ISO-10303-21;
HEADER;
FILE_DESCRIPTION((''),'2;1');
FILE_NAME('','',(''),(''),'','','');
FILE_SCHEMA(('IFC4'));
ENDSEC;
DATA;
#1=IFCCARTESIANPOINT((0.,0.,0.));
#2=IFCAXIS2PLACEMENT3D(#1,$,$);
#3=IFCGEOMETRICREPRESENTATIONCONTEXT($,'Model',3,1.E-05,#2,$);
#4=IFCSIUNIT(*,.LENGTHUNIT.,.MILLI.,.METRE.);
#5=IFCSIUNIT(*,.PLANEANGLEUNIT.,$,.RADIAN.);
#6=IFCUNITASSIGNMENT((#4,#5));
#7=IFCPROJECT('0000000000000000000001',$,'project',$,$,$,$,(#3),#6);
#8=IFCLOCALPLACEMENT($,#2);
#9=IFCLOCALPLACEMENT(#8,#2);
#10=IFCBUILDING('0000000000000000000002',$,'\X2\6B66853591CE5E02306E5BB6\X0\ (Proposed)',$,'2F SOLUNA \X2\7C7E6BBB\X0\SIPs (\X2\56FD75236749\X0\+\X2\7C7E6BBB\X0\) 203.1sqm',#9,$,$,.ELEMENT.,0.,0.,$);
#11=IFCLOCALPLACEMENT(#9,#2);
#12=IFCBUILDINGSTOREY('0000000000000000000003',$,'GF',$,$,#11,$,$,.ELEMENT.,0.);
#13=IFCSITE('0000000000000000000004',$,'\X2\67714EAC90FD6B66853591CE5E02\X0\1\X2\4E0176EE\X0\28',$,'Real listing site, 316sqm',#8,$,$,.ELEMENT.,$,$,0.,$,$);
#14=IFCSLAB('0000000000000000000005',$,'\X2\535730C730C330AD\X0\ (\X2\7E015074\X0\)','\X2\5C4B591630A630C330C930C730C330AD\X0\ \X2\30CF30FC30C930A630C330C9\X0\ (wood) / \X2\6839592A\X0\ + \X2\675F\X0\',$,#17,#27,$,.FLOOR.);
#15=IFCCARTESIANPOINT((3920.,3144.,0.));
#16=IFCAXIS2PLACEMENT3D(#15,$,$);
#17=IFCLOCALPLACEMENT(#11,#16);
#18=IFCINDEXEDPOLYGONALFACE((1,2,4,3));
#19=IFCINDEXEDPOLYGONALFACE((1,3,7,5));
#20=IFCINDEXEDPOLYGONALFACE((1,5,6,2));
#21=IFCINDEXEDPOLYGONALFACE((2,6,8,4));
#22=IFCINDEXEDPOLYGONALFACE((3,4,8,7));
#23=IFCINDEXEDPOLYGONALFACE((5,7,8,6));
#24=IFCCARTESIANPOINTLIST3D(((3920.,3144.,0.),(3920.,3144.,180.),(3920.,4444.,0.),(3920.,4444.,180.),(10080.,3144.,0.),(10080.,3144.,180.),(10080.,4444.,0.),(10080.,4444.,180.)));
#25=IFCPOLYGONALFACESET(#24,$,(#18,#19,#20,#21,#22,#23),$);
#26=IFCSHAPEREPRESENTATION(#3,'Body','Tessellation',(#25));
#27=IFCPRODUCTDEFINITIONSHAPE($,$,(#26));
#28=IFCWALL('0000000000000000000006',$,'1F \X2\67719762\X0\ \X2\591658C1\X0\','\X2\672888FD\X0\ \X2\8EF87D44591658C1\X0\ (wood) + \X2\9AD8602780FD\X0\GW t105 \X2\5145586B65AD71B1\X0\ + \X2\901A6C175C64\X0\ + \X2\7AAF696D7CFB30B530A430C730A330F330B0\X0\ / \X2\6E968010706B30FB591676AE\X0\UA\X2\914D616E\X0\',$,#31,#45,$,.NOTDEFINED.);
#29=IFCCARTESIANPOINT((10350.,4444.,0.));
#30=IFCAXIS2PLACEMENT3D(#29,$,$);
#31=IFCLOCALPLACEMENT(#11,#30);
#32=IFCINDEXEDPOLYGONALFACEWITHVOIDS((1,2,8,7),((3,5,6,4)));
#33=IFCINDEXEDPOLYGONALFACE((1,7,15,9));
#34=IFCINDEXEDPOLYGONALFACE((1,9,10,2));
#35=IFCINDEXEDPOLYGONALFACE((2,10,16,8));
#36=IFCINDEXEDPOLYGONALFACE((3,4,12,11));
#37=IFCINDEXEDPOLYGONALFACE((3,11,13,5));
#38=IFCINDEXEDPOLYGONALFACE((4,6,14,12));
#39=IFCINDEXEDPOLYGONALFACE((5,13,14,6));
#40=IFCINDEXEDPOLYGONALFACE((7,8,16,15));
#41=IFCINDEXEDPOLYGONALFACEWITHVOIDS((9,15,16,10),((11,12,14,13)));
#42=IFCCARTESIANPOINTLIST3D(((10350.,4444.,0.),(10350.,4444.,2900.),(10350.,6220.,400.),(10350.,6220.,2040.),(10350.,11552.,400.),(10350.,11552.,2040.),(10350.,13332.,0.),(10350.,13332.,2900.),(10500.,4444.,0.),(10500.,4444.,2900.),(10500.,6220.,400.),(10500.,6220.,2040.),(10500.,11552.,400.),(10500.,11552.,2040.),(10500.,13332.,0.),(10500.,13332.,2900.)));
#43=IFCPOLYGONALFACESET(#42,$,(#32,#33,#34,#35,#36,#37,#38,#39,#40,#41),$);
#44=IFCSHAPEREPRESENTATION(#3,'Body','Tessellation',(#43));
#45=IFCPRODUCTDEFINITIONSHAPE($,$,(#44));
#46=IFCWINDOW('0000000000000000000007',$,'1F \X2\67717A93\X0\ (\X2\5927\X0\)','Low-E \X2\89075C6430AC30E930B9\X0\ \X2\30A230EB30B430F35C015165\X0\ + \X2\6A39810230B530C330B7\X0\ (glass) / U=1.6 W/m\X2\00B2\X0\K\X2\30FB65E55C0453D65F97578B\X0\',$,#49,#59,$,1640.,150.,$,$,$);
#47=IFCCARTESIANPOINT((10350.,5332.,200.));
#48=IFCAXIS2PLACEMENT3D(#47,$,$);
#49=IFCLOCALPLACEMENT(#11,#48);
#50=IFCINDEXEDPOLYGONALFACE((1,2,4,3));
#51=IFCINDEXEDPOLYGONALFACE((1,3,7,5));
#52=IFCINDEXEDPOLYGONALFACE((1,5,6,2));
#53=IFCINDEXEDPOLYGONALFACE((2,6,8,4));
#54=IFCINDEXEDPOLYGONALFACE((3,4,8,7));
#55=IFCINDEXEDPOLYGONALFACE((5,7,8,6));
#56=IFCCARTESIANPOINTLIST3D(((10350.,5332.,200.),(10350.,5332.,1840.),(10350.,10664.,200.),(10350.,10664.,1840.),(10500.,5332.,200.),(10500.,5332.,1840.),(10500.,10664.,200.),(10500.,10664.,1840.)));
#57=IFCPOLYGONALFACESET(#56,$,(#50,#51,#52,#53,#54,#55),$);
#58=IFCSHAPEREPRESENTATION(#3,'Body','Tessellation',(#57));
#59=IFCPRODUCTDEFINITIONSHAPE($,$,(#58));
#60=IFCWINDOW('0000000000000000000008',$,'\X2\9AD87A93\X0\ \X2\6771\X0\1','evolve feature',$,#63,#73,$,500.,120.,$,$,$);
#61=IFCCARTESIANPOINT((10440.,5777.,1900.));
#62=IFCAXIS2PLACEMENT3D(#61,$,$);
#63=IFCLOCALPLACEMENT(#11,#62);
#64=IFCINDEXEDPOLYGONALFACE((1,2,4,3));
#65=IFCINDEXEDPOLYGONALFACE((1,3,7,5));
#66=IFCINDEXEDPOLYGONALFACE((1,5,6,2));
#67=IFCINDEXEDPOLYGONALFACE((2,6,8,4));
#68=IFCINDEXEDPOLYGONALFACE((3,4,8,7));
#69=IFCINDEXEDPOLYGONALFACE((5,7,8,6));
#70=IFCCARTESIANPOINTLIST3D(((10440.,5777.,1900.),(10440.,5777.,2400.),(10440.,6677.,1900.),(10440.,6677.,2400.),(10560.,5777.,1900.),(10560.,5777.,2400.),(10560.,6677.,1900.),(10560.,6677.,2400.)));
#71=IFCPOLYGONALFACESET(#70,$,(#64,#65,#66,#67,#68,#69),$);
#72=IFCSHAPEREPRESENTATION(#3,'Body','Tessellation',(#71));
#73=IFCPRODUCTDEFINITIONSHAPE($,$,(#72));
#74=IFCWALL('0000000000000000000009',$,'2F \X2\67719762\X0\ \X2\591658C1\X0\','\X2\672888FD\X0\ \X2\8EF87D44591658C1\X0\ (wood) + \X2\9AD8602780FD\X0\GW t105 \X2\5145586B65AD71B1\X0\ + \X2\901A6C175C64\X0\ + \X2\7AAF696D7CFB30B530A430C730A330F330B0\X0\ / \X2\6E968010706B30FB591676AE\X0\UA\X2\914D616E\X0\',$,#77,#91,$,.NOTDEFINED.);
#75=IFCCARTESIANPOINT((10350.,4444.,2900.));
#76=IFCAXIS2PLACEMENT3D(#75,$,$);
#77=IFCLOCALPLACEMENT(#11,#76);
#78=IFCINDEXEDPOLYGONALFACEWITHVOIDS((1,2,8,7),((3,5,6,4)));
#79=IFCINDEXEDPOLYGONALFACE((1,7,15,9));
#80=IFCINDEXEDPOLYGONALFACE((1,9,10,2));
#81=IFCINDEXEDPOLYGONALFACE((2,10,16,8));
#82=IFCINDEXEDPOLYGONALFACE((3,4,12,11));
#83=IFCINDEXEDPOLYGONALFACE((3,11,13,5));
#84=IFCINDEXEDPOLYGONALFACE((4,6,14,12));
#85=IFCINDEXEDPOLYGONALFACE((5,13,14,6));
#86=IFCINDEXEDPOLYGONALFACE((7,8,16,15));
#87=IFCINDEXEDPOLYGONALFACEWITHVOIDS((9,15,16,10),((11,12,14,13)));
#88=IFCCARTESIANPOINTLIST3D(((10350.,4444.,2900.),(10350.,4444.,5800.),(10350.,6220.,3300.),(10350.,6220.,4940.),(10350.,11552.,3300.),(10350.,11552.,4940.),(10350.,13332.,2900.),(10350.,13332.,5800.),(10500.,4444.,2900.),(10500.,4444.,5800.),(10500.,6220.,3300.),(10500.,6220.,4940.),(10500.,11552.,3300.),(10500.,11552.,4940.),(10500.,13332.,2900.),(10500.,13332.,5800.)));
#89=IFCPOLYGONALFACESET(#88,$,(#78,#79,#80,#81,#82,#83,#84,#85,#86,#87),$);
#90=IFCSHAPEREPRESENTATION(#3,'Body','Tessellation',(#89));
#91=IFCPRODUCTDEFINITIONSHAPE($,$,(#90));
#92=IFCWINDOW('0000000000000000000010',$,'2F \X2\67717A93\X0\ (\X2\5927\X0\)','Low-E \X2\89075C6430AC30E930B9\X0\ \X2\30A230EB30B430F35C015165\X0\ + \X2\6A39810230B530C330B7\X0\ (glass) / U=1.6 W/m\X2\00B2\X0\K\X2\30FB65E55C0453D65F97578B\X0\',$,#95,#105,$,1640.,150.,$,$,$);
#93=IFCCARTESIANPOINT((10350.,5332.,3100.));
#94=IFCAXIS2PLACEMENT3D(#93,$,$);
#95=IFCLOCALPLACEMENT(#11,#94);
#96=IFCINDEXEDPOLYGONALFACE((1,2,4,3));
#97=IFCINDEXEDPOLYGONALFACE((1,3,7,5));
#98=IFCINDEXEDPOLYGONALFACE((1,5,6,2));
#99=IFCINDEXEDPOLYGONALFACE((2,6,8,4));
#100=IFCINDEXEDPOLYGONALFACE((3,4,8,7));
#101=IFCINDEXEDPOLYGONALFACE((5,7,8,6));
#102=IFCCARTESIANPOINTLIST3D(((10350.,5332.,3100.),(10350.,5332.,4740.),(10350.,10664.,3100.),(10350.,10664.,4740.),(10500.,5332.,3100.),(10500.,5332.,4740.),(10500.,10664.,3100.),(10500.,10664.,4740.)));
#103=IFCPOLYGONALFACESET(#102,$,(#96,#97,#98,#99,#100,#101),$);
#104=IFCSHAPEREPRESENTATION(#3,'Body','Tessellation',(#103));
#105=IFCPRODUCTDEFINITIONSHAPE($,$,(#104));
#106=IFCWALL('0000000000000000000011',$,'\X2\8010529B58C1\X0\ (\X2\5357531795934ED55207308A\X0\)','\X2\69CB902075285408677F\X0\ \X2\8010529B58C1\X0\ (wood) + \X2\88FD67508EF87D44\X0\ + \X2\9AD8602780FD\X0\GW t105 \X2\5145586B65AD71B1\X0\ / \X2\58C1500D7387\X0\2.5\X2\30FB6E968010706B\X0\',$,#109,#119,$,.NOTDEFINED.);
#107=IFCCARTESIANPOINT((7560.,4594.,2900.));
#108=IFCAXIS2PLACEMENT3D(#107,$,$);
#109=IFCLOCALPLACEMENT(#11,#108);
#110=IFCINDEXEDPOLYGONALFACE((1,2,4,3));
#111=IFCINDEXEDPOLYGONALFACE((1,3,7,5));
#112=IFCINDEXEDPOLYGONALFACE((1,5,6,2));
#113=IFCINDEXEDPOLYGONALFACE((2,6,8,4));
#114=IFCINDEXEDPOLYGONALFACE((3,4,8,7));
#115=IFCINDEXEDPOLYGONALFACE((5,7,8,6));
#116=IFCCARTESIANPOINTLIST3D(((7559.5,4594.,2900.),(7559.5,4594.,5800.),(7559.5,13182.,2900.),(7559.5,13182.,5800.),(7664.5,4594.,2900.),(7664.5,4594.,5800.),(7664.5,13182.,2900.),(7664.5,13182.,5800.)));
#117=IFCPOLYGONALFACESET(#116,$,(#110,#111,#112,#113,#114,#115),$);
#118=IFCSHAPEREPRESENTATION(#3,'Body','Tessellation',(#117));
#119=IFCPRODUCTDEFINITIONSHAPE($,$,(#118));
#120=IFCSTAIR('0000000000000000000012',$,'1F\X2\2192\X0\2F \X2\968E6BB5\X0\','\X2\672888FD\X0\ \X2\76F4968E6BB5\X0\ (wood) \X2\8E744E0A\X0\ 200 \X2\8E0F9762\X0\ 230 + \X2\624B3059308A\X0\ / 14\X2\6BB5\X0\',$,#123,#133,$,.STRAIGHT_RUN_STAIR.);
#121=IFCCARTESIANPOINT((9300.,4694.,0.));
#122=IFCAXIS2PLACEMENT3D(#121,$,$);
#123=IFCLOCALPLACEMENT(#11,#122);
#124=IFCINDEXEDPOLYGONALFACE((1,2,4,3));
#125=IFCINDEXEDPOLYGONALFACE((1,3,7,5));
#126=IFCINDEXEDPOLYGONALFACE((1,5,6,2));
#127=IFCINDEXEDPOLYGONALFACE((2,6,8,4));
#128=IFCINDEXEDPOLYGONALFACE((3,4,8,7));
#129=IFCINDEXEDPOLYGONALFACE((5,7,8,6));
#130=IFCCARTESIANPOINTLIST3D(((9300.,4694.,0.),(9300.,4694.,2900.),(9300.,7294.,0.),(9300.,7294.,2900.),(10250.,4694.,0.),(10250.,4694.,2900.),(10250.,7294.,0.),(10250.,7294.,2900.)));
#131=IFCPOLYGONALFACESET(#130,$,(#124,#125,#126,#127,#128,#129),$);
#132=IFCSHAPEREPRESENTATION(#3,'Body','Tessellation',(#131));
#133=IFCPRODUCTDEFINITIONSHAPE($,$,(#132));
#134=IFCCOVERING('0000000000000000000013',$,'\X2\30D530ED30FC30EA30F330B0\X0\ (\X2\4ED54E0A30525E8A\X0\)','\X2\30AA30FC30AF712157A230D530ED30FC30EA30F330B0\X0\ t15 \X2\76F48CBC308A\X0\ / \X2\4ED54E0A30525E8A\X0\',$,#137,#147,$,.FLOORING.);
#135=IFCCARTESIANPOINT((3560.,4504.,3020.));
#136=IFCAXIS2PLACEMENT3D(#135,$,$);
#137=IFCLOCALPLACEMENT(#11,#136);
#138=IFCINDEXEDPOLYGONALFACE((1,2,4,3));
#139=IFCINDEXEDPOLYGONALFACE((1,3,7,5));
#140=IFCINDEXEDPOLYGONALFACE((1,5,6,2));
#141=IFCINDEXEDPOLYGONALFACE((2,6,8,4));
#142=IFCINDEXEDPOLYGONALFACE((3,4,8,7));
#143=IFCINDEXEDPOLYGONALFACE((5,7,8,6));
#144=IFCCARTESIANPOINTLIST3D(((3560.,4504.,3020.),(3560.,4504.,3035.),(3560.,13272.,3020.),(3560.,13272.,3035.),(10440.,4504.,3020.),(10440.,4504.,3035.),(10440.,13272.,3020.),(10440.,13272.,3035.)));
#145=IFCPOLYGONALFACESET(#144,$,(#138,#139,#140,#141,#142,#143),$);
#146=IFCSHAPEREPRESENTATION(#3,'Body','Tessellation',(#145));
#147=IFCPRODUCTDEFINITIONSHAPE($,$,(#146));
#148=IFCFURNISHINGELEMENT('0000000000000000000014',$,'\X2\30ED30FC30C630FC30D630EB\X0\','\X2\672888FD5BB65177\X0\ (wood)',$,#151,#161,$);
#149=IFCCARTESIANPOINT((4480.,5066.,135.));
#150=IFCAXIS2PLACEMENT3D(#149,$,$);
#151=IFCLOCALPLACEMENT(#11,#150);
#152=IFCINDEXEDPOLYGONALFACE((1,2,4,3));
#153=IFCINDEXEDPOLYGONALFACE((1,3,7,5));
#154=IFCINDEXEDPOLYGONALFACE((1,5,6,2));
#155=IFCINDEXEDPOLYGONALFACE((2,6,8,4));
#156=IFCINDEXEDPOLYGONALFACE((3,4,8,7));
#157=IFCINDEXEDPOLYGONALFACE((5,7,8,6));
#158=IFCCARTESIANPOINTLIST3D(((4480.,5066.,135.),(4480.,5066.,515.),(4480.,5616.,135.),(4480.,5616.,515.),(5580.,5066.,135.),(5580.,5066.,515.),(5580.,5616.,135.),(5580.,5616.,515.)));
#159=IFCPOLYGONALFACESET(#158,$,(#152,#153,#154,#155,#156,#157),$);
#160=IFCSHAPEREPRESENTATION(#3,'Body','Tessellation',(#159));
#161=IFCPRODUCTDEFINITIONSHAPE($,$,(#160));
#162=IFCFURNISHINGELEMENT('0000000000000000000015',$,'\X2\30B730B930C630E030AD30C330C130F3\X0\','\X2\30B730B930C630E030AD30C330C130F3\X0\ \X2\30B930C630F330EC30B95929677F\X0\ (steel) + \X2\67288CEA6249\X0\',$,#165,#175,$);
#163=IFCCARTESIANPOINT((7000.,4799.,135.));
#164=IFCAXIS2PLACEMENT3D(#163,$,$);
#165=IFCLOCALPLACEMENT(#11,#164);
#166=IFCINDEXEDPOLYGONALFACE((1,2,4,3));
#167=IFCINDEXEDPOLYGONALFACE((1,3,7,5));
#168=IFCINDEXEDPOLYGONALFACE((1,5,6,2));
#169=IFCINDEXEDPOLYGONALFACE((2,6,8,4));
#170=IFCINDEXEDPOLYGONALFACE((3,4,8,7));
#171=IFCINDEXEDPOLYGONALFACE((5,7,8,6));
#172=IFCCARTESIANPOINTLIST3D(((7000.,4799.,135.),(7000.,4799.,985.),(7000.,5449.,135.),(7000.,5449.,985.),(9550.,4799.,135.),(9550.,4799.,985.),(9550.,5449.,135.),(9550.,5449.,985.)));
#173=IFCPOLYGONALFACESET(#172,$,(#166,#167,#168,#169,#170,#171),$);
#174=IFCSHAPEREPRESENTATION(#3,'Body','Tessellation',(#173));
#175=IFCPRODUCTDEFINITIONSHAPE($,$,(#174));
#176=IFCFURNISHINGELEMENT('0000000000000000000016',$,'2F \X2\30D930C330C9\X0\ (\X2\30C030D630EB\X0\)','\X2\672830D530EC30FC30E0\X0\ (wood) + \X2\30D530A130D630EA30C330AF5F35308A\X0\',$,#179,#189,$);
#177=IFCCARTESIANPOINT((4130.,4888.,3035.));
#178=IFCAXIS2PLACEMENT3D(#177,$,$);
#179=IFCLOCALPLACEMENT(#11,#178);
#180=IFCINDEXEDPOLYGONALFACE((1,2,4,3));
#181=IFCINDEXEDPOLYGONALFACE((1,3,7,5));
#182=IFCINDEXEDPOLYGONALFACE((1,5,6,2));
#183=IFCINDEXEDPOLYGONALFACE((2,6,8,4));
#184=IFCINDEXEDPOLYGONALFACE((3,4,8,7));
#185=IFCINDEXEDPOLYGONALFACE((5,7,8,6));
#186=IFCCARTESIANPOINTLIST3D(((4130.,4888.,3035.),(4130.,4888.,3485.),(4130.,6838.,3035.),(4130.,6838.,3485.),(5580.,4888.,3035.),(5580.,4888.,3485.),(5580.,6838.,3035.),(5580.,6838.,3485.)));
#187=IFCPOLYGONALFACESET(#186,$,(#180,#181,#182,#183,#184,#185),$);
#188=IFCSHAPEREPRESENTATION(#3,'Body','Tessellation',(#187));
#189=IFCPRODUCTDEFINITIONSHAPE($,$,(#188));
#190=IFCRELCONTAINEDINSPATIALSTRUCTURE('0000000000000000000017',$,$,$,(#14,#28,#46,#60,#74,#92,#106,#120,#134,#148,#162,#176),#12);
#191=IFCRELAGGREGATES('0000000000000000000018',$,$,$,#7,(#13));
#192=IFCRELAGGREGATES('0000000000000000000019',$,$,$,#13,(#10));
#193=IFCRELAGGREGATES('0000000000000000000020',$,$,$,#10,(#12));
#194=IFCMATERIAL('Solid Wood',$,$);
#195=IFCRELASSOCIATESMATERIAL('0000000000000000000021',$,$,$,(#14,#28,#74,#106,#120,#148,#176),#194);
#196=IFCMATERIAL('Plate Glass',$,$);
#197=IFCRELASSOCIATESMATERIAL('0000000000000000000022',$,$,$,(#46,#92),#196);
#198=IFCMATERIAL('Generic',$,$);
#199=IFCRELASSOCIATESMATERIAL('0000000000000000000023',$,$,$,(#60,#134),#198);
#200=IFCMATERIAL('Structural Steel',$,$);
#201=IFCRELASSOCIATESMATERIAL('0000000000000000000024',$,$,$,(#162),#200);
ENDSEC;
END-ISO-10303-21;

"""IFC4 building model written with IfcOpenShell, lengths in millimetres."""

from ifc_helpers import new_model, si_unit, frame, frame_2d, origin, place, context, project, spatial, rectangle, extrude, material, element, fill, save


model = new_model("IFC4")

# Units and contexts
model_context = context("Model", 3, precision=1e-05, world=origin())
ifc_project = project(units=[si_unit("LENGTHUNIT", "METRE", prefix="MILLI"), si_unit("PLANEANGLEUNIT", "RADIAN")], contexts=[model_context])

# Site, building, storey
site_placement = place(None, origin())
site = spatial("IfcSite", under=ifc_project, at=site_placement, Name="東京都武蔵野市1丁目28", ObjectType="Real listing site, 316sqm", CompositionType="ELEMENT", RefElevation=0.0)
building_placement = place(site_placement, origin())
building = spatial("IfcBuilding", under=site, at=building_placement, Name="武蔵野市の家 (Proposed)", ObjectType="2F SOLUNA 籾殻SIPs (国産杉+籾殻) 203.1sqm", CompositionType="ELEMENT", ElevationOfRefHeight=0.0, ElevationOfTerrain=0.0)
storey_placement = place(building_placement, origin())
storey = spatial("IfcBuildingStorey", under=building, at=storey_placement, Name="GF", CompositionType="ELEMENT", Elevation=0.0)

# Slab
ifc_material_1 = material(Name="Solid Wood")
slab_placement = place(storey_placement, frame((3920.0, 3144.0, 0.0)))
element("IfcSlab", 1, at=slab_placement, inside=storey, material=ifc_material_1, Name="南デッキ (縁側)", Description="屋外ウッドデッキ ハードウッド (wood) / 根太 + 束", PredefinedType="FLOOR", context=model_context, shape_type="SweptSolid", body=[
    extrude(rectangle(XDim=6160.0, YDim=1300.0, at=frame_2d((3080.0, 650.0))), frame((3920.0, 3144.0, 0.0)), (0.0, 0.0, 1.0), 180.0),
])

# Wall, openings, windows
wall_1_placement = place(storey_placement, frame((10350.0, 4444.0, 0.0)))
wall_1 = element("IfcWall", 2, at=wall_1_placement, inside=storey, material=ifc_material_1, Name="1F 東面 外壁", Description="木製 軸組外壁 (wood) + 高性能GW t105 充填断熱 + 通気層 + 窯業系サイディング / 準耐火・外皮UA配慮", PredefinedType="NOTDEFINED", context=model_context, shape_type="SweptSolid", body=[
    extrude(rectangle(XDim=150.0, YDim=8888.0, at=frame_2d((75.0, 4444.0))), frame((10350.0, 4444.0, 0.0)), (0.0, 0.0, 1.0), 2900.0),
])
opening_1_placement = place(storey_placement, frame((10350.0, 5332.0, 200.0)))
opening_1 = element("IfcOpeningElement", 3, at=opening_1_placement, cuts=wall_1, PredefinedType="NOTDEFINED", context=model_context, shape_type="SweptSolid", body=[
    extrude(rectangle(XDim=150.0, YDim=5332.0, at=frame_2d((75.0, 2666.0))), frame((10350.0, 5332.0, 200.0)), (0.0, 0.0, 1.0), 1640.0),
])
opening_2_placement = place(storey_placement, frame((10440.0, 5777.0, 1900.0)))
opening_2 = element("IfcOpeningElement", 4, at=opening_2_placement, cuts=wall_1, PredefinedType="NOTDEFINED", context=model_context, shape_type="SweptSolid", body=[
    extrude(rectangle(XDim=120.0, YDim=900.0, at=frame_2d((60.0, 450.0))), frame((10440.0, 5777.0, 1900.0)), (0.0, 0.0, 1.0), 500.0),
])
ifc_material_2 = material(Name="Plate Glass")
window_1_placement = place(storey_placement, frame((10350.0, 5332.0, 200.0)))
window_1 = element("IfcWindow", 5, at=window_1_placement, inside=storey, material=ifc_material_2, Name="1F 東窓 (大)", Description="Low-E 複層ガラス アルゴン封入 + 樹脂サッシ (glass) / U=1.6 W/m²K・日射取得型", OverallHeight=1640.0, OverallWidth=150.0, context=model_context, shape_type="SweptSolid", body=[
    extrude(rectangle(XDim=150.0, YDim=5332.0, at=frame_2d((75.0, 2666.0))), frame((10350.0, 5332.0, 200.0)), (0.0, 0.0, 1.0), 1640.0),
])
fill(opening_1, window_1)
ifc_material_3 = material(Name="Generic")
window_2_placement = place(storey_placement, frame((10440.0, 5777.0, 1900.0)))
window_2 = element("IfcWindow", 6, at=window_2_placement, inside=storey, material=ifc_material_3, Name="高窓 東1", Description="evolve feature", OverallHeight=500.0, OverallWidth=120.0, context=model_context, shape_type="SweptSolid", body=[
    extrude(rectangle(XDim=120.0, YDim=900.0, at=frame_2d((60.0, 450.0))), frame((10440.0, 5777.0, 1900.0)), (0.0, 0.0, 1.0), 500.0),
])
fill(opening_2, window_2)

# Wall, opening, window
wall_2_placement = place(storey_placement, frame((10350.0, 4444.0, 2900.0)))
wall_2 = element("IfcWall", 7, at=wall_2_placement, inside=storey, material=ifc_material_1, Name="2F 東面 外壁", Description="木製 軸組外壁 (wood) + 高性能GW t105 充填断熱 + 通気層 + 窯業系サイディング / 準耐火・外皮UA配慮", PredefinedType="NOTDEFINED", context=model_context, shape_type="SweptSolid", body=[
    extrude(rectangle(XDim=150.0, YDim=8888.0, at=frame_2d((75.0, 4444.0))), frame((10350.0, 4444.0, 2900.0)), (0.0, 0.0, 1.0), 2900.0),
])
opening_3_placement = place(storey_placement, frame((10350.0, 5332.0, 3100.0)))
opening_3 = element("IfcOpeningElement", 8, at=opening_3_placement, cuts=wall_2, PredefinedType="NOTDEFINED", context=model_context, shape_type="SweptSolid", body=[
    extrude(rectangle(XDim=150.0, YDim=5332.0, at=frame_2d((75.0, 2666.0))), frame((10350.0, 5332.0, 3100.0)), (0.0, 0.0, 1.0), 1640.0),
])
window_3_placement = place(storey_placement, frame((10350.0, 5332.0, 3100.0)))
window_3 = element("IfcWindow", 9, at=window_3_placement, inside=storey, material=ifc_material_2, Name="2F 東窓 (大)", Description="Low-E 複層ガラス アルゴン封入 + 樹脂サッシ (glass) / U=1.6 W/m²K・日射取得型", OverallHeight=1640.0, OverallWidth=150.0, context=model_context, shape_type="SweptSolid", body=[
    extrude(rectangle(XDim=150.0, YDim=5332.0, at=frame_2d((75.0, 2666.0))), frame((10350.0, 5332.0, 3100.0)), (0.0, 0.0, 1.0), 1640.0),
])
fill(opening_3, window_3)

# Wall
wall_3_placement = place(storey_placement, frame((7560.0, 4594.0, 2900.0)))
element("IfcWall", 10, at=wall_3_placement, inside=storey, material=ifc_material_1, Name="耐力壁 (南北間仕切り)", Description="構造用合板 耐力壁 (wood) + 製材軸組 + 高性能GW t105 充填断熱 / 壁倍率2.5・準耐火", PredefinedType="NOTDEFINED", context=model_context, shape_type="SweptSolid", body=[
    extrude(rectangle(XDim=105.0, YDim=8588.0, at=frame_2d((52.0, 4294.0))), frame((7560.0, 4594.0, 2900.0)), (0.0, 0.0, 1.0), 2900.0),
])

# Stair
stair_placement = place(storey_placement, frame((9300.0, 4694.0, 0.0)))
element("IfcStair", 11, at=stair_placement, inside=storey, material=ifc_material_1, Name="1F→2F 階段", Description="木製 直階段 (wood) 蹴上 200 踏面 230 + 手すり / 14段", PredefinedType="STRAIGHT_RUN_STAIR", context=model_context, shape_type="SweptSolid", body=[
    extrude(rectangle(XDim=950.0, YDim=2600.0, at=frame_2d((475.0, 1300.0))), frame((9300.0, 4694.0, 0.0)), (0.0, 0.0, 1.0), 2900.0),
])

# Covering
covering_placement = place(storey_placement, frame((3560.0, 4504.0, 3020.0)))
element("IfcCovering", 12, at=covering_placement, inside=storey, material=ifc_material_3, Name="フローリング (仕上げ床)", Description="オーク無垢フローリング t15 直貼り / 仕上げ床", PredefinedType="FLOORING", context=model_context, shape_type="SweptSolid", body=[
    extrude(rectangle(XDim=6880.0, YDim=8768.0, at=frame_2d((3440.0, 4384.0))), frame((3560.0, 4504.0, 3020.0)), (0.0, 0.0, 1.0), 15.0),
])

# Furnishing elements
furnishing_1_placement = place(storey_placement, frame((4480.0, 5066.0, 135.0)))
element("IfcFurnishingElement", 13, at=furnishing_1_placement, inside=storey, material=ifc_material_1, Name="ローテーブル", Description="木製家具 (wood)", context=model_context, shape_type="SweptSolid", body=[
    extrude(rectangle(XDim=1100.0, YDim=550.0, at=frame_2d((550.0, 275.0))), frame((4480.0, 5066.0, 135.0)), (0.0, 0.0, 1.0), 380.0),
])
ifc_material_4 = material(Name="Structural Steel")
furnishing_2_placement = place(storey_placement, frame((7000.0, 4799.0, 135.0)))
element("IfcFurnishingElement", 14, at=furnishing_2_placement, inside=storey, material=ifc_material_4, Name="システムキッチン", Description="システムキッチン ステンレス天板 (steel) + 木質扉", context=model_context, shape_type="SweptSolid", body=[
    extrude(rectangle(XDim=2550.0, YDim=650.0, at=frame_2d((1275.0, 325.0))), frame((7000.0, 4799.0, 135.0)), (0.0, 0.0, 1.0), 850.0),
])
furnishing_3_placement = place(storey_placement, frame((4130.0, 4888.0, 3035.0)))
element("IfcFurnishingElement", 15, at=furnishing_3_placement, inside=storey, material=ifc_material_1, Name="2F ベッド (ダブル)", Description="木フレーム (wood) + ファブリック張り", context=model_context, shape_type="SweptSolid", body=[
    extrude(rectangle(XDim=1450.0, YDim=1950.0, at=frame_2d((725.0, 975.0))), frame((4130.0, 4888.0, 3035.0)), (0.0, 0.0, 1.0), 450.0),
])

save(model, "model.ifc")
